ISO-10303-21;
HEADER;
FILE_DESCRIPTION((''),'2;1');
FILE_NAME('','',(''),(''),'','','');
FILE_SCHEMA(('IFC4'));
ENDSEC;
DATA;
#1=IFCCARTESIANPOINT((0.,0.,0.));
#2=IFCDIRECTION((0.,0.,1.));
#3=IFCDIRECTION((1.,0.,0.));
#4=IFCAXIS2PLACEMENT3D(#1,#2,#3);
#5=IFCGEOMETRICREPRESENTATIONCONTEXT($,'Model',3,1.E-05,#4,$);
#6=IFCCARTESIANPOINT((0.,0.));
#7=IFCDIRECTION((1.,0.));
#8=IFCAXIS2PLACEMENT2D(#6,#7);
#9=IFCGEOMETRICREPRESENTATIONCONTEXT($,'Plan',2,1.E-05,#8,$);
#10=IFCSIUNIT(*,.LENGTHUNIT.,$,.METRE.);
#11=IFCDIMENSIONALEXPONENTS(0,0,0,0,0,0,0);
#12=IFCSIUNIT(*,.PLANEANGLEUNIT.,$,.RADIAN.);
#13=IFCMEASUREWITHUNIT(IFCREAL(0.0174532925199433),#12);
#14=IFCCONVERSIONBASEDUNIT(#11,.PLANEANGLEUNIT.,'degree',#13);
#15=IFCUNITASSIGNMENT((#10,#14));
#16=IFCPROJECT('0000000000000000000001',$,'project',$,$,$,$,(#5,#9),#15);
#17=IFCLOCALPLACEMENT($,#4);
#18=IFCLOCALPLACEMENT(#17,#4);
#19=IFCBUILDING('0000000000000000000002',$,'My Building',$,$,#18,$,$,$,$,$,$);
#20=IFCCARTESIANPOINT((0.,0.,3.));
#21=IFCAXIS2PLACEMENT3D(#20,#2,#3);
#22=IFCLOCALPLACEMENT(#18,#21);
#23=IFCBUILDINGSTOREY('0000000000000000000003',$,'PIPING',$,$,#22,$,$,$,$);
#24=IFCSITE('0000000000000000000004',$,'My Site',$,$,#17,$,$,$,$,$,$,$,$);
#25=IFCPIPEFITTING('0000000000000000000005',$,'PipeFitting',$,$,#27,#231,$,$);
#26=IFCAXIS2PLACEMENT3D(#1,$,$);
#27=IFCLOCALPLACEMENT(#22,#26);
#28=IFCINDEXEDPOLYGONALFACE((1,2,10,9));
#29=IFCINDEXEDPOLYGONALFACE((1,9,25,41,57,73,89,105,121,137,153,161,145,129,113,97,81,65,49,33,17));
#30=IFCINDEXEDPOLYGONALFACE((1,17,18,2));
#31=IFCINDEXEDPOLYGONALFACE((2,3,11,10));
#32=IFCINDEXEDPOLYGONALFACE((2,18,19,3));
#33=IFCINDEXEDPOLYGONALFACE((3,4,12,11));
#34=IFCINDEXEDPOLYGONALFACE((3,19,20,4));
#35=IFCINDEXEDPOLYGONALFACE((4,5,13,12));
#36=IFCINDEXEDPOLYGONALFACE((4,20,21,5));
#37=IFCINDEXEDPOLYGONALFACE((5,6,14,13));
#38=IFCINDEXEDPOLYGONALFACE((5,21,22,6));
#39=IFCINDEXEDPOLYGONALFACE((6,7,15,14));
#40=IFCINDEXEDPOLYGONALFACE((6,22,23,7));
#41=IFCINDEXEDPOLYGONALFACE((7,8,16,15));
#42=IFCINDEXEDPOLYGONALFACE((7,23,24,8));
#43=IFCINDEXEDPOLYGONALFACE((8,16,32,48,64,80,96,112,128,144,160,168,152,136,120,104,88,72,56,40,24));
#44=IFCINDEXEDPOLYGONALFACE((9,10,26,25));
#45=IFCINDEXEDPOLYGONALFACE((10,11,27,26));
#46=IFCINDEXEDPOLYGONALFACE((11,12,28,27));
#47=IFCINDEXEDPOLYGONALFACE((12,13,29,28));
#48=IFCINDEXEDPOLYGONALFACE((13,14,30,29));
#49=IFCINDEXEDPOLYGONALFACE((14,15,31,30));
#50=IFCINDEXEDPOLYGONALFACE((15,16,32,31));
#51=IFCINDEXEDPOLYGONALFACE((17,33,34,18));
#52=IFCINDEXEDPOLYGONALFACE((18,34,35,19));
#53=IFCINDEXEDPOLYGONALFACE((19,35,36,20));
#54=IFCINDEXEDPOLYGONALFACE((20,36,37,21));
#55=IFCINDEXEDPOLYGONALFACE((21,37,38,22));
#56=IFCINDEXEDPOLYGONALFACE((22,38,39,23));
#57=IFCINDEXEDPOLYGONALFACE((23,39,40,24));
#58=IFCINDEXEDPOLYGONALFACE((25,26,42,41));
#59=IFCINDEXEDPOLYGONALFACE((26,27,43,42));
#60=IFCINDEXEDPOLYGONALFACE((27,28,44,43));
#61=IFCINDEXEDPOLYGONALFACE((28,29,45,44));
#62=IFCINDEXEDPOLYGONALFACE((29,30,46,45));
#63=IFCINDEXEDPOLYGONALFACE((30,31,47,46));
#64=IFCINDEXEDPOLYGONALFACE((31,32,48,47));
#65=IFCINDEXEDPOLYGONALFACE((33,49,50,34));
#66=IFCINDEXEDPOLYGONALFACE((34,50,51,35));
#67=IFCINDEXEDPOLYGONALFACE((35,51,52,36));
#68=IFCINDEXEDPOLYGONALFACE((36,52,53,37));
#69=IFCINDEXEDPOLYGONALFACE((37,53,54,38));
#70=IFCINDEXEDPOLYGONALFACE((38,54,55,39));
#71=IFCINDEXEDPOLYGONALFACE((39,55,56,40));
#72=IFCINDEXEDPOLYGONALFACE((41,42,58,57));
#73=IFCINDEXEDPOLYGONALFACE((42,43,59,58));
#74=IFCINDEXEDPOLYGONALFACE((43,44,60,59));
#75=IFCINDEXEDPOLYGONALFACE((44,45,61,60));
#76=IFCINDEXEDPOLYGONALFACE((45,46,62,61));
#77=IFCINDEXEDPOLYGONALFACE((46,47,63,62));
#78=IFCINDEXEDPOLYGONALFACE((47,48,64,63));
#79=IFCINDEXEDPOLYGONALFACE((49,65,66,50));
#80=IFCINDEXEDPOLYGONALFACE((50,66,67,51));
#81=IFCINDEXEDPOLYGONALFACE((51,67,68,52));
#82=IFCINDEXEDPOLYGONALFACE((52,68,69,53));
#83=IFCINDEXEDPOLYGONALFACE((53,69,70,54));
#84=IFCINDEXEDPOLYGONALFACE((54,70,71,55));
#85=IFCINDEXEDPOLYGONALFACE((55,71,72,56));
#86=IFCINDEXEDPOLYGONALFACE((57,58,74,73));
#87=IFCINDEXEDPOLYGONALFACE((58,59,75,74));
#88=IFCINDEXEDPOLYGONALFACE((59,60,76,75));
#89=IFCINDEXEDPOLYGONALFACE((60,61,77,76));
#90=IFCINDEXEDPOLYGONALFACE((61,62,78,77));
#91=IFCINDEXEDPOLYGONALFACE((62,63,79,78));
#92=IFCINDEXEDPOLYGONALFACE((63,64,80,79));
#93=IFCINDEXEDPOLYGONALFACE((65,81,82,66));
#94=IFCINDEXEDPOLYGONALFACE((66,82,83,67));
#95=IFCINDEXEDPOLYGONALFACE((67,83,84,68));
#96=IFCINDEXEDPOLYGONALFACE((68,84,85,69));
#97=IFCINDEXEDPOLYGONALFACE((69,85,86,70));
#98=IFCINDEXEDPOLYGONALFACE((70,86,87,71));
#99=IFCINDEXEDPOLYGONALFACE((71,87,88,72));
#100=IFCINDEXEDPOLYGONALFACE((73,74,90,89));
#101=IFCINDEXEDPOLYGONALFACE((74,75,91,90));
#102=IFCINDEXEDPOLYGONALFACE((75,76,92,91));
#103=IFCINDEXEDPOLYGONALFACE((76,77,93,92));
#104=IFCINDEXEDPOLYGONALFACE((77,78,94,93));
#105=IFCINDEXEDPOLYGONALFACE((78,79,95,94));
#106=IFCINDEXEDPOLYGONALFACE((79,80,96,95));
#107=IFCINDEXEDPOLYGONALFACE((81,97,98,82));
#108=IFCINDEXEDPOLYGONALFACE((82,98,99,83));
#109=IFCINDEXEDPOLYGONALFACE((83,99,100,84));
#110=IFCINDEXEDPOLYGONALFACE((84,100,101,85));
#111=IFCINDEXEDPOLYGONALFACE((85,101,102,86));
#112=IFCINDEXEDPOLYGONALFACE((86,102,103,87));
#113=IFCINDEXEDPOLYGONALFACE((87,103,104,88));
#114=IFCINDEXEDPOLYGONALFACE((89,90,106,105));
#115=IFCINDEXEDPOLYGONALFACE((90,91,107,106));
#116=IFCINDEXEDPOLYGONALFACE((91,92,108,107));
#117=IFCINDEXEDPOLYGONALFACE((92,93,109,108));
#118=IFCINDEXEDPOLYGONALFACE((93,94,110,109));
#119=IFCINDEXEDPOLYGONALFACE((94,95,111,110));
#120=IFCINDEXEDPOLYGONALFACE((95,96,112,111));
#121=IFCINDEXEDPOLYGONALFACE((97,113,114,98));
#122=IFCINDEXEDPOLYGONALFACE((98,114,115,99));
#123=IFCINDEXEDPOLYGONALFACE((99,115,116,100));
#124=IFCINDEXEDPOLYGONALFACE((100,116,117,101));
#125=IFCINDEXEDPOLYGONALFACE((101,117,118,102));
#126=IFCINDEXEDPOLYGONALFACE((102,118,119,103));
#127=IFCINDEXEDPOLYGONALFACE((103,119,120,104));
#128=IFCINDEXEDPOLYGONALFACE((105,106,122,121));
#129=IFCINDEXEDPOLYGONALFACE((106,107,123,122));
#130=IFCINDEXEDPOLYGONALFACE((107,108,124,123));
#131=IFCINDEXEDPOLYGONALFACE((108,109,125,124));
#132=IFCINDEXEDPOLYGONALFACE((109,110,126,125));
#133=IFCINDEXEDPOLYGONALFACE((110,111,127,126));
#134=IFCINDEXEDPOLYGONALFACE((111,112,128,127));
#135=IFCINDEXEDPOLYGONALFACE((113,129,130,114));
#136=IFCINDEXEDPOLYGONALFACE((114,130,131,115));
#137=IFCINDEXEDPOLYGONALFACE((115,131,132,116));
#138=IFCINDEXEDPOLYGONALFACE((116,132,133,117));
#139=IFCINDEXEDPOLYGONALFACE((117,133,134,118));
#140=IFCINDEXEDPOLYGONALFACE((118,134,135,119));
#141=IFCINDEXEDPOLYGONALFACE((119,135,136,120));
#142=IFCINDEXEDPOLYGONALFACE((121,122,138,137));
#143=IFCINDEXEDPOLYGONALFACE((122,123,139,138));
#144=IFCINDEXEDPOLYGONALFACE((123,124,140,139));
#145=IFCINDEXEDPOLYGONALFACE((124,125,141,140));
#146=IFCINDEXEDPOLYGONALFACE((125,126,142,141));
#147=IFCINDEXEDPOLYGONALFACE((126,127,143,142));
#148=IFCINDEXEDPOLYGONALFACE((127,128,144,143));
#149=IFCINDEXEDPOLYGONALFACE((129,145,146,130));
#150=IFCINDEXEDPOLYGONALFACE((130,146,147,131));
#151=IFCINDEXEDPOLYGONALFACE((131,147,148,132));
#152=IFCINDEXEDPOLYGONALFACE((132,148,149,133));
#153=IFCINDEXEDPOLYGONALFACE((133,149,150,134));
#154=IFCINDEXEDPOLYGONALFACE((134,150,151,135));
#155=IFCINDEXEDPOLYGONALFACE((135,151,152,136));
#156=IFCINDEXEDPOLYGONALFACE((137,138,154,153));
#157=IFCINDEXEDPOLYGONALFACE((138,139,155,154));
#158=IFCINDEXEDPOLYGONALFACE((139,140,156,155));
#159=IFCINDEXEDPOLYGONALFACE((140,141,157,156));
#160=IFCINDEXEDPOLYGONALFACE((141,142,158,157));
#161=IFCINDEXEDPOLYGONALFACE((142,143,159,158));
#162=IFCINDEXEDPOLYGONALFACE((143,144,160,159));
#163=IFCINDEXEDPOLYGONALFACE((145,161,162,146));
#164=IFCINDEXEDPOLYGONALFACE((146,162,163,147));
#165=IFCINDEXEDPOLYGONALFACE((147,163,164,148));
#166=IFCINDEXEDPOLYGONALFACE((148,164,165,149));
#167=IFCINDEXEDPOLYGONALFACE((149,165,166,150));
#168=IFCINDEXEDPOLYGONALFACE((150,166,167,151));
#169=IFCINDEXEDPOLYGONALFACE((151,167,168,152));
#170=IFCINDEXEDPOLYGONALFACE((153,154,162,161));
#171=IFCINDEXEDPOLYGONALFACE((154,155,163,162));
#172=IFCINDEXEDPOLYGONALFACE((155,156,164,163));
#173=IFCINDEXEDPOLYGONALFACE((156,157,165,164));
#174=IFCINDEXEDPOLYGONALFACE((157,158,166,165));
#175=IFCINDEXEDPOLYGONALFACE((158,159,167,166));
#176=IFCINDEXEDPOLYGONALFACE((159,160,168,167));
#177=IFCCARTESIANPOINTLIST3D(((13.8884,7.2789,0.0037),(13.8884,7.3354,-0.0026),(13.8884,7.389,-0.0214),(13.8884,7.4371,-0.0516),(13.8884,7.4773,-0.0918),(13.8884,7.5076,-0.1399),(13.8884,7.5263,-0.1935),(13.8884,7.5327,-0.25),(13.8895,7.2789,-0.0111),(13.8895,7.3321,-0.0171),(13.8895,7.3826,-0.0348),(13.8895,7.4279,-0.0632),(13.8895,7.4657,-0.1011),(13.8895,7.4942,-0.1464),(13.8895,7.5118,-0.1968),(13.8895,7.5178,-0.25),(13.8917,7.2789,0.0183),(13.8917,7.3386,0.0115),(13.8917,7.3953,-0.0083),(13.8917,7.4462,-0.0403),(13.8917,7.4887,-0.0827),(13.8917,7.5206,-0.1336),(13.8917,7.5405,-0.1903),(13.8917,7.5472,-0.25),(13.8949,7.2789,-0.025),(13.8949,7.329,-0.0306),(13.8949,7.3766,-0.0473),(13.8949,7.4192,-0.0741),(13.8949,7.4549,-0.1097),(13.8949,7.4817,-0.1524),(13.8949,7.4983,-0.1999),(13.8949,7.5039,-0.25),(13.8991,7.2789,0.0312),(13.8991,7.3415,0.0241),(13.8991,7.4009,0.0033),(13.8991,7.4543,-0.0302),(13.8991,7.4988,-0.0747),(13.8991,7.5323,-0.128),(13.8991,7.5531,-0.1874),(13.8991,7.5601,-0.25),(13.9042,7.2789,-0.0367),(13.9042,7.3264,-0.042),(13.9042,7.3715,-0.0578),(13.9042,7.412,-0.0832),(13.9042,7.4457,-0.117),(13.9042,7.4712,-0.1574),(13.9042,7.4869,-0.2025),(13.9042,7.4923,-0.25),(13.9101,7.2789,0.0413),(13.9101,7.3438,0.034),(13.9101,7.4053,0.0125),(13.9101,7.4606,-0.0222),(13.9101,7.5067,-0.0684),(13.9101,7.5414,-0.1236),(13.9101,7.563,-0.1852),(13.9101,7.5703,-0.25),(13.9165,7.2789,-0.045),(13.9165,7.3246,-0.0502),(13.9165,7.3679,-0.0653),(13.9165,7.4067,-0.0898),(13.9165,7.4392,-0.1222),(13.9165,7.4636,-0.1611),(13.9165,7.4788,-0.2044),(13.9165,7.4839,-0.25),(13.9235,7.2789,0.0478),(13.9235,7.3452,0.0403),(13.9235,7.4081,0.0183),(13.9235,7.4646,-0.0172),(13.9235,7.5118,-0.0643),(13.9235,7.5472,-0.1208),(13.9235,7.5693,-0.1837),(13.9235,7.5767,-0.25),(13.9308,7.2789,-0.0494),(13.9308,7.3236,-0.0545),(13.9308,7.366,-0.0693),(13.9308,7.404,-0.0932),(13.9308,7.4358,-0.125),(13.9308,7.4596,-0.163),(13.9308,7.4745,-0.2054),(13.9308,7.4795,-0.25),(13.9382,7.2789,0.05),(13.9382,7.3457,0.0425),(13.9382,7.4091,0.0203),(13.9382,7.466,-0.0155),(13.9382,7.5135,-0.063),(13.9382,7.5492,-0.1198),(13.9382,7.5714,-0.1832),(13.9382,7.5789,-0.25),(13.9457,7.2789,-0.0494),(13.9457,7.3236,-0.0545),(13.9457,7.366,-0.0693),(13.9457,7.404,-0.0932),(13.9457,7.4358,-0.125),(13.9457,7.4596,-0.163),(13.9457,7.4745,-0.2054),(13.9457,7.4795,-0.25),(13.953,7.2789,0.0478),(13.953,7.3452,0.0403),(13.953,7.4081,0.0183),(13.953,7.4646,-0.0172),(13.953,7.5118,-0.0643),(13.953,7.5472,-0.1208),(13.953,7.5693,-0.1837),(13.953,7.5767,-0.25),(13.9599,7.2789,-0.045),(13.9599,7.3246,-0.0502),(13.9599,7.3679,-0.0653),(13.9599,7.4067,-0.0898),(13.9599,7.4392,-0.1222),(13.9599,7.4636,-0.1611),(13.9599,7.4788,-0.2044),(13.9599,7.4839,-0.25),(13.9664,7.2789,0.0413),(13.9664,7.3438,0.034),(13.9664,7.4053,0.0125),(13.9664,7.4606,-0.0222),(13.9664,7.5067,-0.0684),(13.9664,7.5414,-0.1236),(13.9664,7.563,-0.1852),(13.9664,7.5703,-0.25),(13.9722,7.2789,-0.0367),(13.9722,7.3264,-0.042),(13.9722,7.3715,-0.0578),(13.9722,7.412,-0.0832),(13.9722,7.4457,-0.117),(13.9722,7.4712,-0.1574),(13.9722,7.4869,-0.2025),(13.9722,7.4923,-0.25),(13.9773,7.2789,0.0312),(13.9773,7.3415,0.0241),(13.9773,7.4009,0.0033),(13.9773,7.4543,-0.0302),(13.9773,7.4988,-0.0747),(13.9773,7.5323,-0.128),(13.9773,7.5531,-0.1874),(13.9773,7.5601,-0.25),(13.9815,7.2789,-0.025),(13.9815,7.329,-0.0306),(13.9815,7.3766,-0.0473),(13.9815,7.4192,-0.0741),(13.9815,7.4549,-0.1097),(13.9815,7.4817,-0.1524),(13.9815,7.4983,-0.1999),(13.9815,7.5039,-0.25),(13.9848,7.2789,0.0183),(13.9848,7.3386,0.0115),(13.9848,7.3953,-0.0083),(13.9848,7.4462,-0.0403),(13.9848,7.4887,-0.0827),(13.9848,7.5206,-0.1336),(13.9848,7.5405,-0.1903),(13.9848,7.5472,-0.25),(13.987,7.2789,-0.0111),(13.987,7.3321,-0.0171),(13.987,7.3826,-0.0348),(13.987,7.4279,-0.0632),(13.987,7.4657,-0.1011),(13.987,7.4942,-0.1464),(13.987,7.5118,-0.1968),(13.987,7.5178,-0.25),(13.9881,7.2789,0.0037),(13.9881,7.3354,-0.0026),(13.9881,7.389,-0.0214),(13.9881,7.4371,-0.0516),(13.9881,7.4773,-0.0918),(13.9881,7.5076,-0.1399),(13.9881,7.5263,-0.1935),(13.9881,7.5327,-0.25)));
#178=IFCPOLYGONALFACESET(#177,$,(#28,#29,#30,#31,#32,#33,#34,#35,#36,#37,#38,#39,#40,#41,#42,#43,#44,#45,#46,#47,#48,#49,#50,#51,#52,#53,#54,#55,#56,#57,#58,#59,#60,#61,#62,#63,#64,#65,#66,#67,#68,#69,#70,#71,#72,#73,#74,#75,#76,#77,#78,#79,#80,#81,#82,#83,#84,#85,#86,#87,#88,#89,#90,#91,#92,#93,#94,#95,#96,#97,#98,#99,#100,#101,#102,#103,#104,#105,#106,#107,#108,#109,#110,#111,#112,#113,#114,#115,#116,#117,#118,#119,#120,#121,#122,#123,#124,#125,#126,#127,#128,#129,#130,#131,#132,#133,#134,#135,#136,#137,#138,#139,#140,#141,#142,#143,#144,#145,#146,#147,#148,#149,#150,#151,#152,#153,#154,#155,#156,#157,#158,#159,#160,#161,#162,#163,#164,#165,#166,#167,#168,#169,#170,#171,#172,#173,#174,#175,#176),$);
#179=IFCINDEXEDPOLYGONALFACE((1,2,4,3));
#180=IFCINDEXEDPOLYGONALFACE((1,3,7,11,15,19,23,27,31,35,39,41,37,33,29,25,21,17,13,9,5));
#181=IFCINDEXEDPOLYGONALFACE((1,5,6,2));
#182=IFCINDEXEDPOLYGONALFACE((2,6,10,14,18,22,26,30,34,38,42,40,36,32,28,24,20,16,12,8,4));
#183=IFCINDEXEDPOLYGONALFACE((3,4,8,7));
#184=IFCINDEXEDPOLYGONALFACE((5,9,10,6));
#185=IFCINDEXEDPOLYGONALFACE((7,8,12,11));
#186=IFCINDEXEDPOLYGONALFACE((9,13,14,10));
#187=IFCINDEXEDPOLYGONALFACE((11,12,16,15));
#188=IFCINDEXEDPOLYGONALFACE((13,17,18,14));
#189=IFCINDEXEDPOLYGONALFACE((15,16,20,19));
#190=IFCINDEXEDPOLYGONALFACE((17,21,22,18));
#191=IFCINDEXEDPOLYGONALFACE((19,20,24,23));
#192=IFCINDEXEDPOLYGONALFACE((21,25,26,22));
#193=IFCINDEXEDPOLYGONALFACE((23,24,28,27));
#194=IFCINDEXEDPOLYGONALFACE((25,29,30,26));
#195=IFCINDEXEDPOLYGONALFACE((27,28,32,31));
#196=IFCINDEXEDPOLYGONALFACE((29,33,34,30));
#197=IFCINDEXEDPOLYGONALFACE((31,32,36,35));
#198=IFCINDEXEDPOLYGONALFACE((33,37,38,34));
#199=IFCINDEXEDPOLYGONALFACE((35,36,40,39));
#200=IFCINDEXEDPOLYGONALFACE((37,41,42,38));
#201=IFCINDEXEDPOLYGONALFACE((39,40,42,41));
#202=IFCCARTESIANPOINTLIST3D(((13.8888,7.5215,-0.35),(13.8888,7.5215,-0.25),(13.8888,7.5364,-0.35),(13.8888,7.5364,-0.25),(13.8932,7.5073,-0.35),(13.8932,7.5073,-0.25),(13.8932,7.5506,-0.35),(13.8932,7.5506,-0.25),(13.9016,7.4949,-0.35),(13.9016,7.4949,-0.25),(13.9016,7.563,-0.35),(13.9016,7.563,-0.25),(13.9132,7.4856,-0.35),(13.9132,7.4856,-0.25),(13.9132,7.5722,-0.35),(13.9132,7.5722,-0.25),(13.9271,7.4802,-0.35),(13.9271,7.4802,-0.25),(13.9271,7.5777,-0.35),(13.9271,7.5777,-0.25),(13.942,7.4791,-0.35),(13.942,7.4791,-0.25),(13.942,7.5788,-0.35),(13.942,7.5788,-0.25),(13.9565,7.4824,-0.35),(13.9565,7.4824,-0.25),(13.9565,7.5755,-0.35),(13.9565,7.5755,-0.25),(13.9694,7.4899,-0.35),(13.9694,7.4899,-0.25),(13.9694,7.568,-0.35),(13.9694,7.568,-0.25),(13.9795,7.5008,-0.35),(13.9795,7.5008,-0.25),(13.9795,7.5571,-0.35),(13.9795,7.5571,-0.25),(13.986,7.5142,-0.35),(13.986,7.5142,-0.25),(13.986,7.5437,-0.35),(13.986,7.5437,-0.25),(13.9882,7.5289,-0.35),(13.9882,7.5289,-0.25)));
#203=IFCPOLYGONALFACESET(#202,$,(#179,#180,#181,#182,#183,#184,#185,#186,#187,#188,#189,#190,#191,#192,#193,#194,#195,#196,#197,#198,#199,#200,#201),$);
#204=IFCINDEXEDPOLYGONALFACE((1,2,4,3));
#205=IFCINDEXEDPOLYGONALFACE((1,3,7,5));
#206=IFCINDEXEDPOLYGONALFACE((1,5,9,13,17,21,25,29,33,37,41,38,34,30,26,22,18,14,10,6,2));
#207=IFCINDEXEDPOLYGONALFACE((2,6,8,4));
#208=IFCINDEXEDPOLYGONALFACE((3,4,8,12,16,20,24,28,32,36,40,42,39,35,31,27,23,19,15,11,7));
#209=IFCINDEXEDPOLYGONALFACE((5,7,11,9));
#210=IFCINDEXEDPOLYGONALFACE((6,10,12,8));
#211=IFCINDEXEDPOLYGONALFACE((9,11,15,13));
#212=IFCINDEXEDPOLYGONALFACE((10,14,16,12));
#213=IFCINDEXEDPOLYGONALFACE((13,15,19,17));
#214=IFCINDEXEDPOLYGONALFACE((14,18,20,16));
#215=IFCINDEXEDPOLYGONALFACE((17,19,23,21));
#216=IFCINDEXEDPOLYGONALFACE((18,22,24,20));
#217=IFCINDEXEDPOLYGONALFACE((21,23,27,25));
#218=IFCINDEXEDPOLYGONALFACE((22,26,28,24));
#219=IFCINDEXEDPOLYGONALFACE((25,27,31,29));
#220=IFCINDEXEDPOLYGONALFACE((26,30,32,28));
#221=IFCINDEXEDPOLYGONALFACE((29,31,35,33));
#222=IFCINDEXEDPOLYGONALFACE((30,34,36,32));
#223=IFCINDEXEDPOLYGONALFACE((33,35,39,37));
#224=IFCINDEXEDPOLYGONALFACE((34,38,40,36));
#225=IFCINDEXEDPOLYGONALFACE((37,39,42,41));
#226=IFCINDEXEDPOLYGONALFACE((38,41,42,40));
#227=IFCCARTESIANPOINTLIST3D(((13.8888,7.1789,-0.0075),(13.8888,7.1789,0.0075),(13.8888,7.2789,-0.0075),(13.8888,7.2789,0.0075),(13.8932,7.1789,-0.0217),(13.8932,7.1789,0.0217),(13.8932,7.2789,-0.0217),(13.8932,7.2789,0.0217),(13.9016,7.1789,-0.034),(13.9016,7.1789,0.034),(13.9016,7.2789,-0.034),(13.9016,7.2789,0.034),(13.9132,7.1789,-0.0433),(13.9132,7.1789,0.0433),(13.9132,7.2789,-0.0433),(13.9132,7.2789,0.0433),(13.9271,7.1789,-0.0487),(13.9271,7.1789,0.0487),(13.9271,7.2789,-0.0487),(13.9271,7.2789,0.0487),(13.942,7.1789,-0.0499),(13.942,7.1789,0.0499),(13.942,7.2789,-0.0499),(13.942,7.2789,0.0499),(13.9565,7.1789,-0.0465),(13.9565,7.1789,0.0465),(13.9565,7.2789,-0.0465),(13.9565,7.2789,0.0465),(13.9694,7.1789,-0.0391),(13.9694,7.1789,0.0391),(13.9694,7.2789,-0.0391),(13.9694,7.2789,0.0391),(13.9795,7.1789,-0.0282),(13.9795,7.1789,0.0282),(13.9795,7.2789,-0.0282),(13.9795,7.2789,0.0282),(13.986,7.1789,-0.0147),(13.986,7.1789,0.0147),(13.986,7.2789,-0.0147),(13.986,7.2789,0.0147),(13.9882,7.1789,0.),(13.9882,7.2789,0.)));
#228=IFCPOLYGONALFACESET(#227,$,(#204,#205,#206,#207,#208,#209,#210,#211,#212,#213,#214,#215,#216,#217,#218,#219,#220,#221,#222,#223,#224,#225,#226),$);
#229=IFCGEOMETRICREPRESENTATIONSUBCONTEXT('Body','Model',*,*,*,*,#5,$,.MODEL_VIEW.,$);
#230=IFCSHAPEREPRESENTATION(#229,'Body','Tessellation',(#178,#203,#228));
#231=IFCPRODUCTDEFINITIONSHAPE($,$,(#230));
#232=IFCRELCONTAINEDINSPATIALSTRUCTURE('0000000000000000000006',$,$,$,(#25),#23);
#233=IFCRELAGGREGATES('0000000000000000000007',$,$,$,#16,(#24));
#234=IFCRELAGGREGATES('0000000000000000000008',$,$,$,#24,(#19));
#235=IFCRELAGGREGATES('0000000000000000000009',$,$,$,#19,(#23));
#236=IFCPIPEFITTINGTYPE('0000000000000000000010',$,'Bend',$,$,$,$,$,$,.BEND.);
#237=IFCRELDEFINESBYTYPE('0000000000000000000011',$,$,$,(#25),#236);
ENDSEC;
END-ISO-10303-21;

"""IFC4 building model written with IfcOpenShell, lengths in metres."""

from ifc_helpers import new_model, entity, si_unit, converted_unit, frame, origin_with_axes, origin_2d_with_axis, place, context, subcontext, project, spatial, circle, extrude, source, transform, mapped, type_object, type_shapes, element, save


model = new_model("IFC4")

# Units and contexts
model_context = context("Model", 3, precision=1e-05, world=origin_with_axes())
plan_context = context("Plan", 2, precision=1e-05, world=origin_2d_with_axis())
body_context = subcontext(model_context, "Body", "Model", "MODEL_VIEW")
ifc_project = project(units=[si_unit("LENGTHUNIT", "METRE"), converted_unit("PLANEANGLEUNIT", "degree", entity("IfcReal", 0.0174532925199433), si_unit("PLANEANGLEUNIT", "RADIAN"), dimensions=[0, 0, 0, 0, 0, 0, 0])], contexts=[model_context, plan_context])

# Site, building, storey
site_placement = place(None, origin_with_axes())
site = spatial("IfcSite", under=ifc_project, at=site_placement, Name="My Site")
building_placement = place(site_placement, origin_with_axes())
building = spatial("IfcBuilding", under=site, at=building_placement, Name="My Building")
storey_placement = place(building_placement, frame((0.0, 0.0, 3.0), z_axis=(0.0, 0.0, 1.0), x_axis=(1.0, 0.0, 0.0)))
storey = spatial("IfcBuildingStorey", under=building, at=storey_placement, Name="PIPING")

# Pipe fitting
pipe_fitting_type_1 = type_object("IfcPipeFittingType", Name="Bend", PredefinedType="BEND")
shared_shape = source(origin_with_axes(), body_context, "Body", "SolidModel", [
    entity("IfcSweptDiskSolid", entity("IfcIndexedPolyCurve", entity("IfcCartesianPointList3D", [[0.0, 0.0, -0.1], [0.0, 0.0732, -0.2768], [0.0, 0.25, -0.35]]), [entity("IfcArcIndex", [1, 2, 3])]), 0.05),
    extrude(circle(Radius=0.05), origin_with_axes(), (0.0, 0.0, -1.0), 0.1),
    extrude(circle(Radius=0.05), frame((0.0, 0.25, -0.35), z_axis=(0.0, 1.0, 0.0), x_axis=(1.0, 0.0, 0.0)), (0.0, 0.0, 1.0), 0.1),
])
type_shapes(pipe_fitting_type_1, [shared_shape])
for number, where, z_axis, x_axis, name in (
    (1, (13.9382, 7.5289, -0.35), (0.0, 0.0, -1.0), (1.0, 0.0, 0.0), "PipeFitting"),
):
    element("IfcPipeFitting", number, at=place(storey_placement, frame(where, z_axis=z_axis, x_axis=x_axis)), inside=storey, type_object=pipe_fitting_type_1, Name=name, context=body_context, shape_type="MappedRepresentation", body=[
        mapped(shared_shape, transform((0.0, 0.0, 0.0), x_axis=(1.0, 0.0, 0.0), y_axis=(0.0, 1.0, 0.0), z_axis=(0.0, 0.0, 1.0), scale=1.0)),
    ])

save(model, "model.ifc")
